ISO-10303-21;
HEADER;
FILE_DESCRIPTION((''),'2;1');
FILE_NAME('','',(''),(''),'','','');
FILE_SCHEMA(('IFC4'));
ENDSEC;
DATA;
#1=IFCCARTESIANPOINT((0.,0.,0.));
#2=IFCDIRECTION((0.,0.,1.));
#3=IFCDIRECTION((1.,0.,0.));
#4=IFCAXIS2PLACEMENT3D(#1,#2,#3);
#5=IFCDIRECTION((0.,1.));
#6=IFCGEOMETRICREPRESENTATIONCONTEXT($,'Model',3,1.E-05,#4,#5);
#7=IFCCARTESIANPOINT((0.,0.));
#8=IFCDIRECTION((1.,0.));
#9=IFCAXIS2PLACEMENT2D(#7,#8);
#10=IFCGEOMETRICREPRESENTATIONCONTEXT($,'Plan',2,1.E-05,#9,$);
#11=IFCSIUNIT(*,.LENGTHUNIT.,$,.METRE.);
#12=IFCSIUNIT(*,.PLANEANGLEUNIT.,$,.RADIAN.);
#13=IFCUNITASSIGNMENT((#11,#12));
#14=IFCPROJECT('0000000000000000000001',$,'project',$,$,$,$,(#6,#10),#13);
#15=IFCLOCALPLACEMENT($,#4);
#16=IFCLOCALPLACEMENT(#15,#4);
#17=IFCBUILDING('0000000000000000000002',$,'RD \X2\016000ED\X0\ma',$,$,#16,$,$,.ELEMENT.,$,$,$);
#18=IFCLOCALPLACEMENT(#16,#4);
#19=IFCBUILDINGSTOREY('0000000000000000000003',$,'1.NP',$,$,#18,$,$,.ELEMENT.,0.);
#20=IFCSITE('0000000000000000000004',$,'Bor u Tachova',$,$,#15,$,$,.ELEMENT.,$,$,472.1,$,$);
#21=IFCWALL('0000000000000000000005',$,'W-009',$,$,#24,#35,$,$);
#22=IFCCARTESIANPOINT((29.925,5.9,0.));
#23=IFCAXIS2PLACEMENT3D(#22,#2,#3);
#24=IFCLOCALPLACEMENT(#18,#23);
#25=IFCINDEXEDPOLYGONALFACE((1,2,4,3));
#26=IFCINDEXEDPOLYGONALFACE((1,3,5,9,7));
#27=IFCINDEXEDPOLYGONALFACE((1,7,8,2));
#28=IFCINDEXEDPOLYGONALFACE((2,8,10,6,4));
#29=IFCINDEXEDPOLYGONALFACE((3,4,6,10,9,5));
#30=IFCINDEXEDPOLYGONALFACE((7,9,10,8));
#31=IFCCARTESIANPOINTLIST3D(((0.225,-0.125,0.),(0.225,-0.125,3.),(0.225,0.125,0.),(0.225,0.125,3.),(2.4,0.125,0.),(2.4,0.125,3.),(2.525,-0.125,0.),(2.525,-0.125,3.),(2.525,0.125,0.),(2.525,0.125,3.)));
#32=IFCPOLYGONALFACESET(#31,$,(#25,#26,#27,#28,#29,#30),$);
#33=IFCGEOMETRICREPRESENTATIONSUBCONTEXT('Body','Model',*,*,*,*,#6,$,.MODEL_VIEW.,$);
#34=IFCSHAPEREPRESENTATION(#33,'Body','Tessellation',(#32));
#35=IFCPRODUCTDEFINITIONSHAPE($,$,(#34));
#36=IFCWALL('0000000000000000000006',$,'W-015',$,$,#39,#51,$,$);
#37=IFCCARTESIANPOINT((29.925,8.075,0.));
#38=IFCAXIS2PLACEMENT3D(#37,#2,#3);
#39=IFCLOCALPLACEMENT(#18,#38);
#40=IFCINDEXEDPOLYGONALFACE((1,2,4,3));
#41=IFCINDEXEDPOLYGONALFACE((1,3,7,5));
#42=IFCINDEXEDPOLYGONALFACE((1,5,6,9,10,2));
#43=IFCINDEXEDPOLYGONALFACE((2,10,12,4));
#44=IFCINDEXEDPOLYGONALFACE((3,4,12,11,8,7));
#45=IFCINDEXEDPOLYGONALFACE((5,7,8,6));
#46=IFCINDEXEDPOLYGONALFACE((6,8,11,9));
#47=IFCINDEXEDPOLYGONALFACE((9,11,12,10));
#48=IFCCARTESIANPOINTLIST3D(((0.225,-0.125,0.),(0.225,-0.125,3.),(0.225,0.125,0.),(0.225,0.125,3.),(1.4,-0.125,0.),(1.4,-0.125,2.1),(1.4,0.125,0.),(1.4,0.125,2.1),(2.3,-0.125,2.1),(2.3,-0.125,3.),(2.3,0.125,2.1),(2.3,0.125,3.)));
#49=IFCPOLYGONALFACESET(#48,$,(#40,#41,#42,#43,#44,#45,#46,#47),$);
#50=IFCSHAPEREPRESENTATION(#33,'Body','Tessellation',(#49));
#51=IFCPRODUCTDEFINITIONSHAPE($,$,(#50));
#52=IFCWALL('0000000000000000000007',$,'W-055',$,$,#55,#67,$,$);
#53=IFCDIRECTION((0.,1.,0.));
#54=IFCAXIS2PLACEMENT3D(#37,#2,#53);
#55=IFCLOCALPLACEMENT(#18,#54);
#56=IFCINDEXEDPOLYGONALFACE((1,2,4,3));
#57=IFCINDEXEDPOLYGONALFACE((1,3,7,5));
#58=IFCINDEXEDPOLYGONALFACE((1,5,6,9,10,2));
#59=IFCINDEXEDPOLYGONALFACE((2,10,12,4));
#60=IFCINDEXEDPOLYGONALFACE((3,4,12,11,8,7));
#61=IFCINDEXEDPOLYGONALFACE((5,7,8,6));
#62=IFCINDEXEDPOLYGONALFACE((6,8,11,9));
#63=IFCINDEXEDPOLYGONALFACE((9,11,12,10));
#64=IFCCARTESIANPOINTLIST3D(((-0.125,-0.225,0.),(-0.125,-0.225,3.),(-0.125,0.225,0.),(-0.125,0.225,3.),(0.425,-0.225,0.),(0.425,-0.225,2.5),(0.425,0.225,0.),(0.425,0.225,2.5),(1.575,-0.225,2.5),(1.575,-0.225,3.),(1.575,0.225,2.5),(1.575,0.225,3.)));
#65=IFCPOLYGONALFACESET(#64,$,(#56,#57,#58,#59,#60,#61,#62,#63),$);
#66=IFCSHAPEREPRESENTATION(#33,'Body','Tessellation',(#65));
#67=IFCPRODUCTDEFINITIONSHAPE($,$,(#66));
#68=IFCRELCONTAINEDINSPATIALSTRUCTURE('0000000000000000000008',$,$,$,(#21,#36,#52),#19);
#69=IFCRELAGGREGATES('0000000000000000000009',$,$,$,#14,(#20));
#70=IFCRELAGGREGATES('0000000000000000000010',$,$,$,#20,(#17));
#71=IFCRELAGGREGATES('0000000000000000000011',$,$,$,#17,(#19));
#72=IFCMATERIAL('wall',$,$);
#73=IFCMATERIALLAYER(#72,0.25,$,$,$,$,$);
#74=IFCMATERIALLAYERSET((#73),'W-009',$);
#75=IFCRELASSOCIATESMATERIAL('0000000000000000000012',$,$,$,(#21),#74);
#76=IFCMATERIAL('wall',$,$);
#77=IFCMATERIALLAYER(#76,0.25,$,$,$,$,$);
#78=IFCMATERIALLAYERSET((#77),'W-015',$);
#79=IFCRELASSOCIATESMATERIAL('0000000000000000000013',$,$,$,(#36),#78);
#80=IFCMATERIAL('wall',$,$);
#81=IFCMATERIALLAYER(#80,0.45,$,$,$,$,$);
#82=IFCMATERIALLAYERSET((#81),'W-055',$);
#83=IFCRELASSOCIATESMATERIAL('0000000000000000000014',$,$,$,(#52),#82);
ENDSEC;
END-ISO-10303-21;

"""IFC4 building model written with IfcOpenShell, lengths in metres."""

from ifc_helpers import new_model, si_unit, direction, frame, frame_2d, origin_with_axes, origin_2d_with_axis, place, context, subcontext, project, spatial, line, indexed_curve, rectangle, outline, extrude, material, layer, layer_set, layer_usage, element, save


model = new_model("IFC4")

# Units and contexts
model_context = context("Model", 3, precision=1e-05, world=origin_with_axes(), true_north=direction((0.0, 1.0)))
plan_context = context("Plan", 2, precision=1e-05, world=origin_2d_with_axis())
body_context = subcontext(model_context, "Body", "Model", "MODEL_VIEW")
ifc_project = project(units=[si_unit("LENGTHUNIT", "METRE"), si_unit("PLANEANGLEUNIT", "RADIAN")], contexts=[model_context, plan_context])

# Site, building, storey
site_placement = place(None, origin_with_axes())
site = spatial("IfcSite", under=ifc_project, at=site_placement, Name="Bor u Tachova", CompositionType="ELEMENT", RefElevation=472.1)
building_placement = place(site_placement, origin_with_axes())
building = spatial("IfcBuilding", under=site, at=building_placement, Name="RD Šíma", CompositionType="ELEMENT")
storey_placement = place(building_placement, origin_with_axes())
storey = spatial("IfcBuildingStorey", under=building, at=storey_placement, Name="1.NP", CompositionType="ELEMENT", Elevation=0.0)

# Wall
ifc_material_1 = material(Name="wall")
ifc_layer_1 = layer(ifc_material_1, 0.25)
ifc_layer_set_1 = layer_set([ifc_layer_1], Name="W-009")
ifc_layer_usage_1 = layer_usage(ifc_layer_set_1, "AXIS2", "POSITIVE", -0.125)
wall_1_placement = place(storey_placement, frame((29.925, 5.9, 0.0), z_axis=(0.0, 0.0, 1.0), x_axis=(1.0, 0.0, 0.0)))
element("IfcWall", 1, at=wall_1_placement, inside=storey, material=ifc_layer_usage_1, Name="W-009", context=body_context, shape_type="SweptSolid", body=[
    extrude(outline(indexed_curve([(0.225, -0.125), (0.225, 0.125), (2.4, 0.125), (2.525, 0.125), (2.525, -0.125)], segments=[line(1, 2, 3, 4, 5, 1)])), origin_with_axes(), (0.0, 0.0, 1.0), 3.0),
])

# Wall, opening
ifc_material_2 = material(Name="wall")
ifc_layer_2 = layer(ifc_material_2, 0.25)
ifc_layer_set_2 = layer_set([ifc_layer_2], Name="W-015")
ifc_layer_usage_2 = layer_usage(ifc_layer_set_2, "AXIS2", "POSITIVE", -0.125)
wall_2_placement = place(storey_placement, frame((29.925, 8.075, 0.0), z_axis=(0.0, 0.0, 1.0), x_axis=(1.0, 0.0, 0.0)))
wall_2 = element("IfcWall", 2, at=wall_2_placement, inside=storey, material=ifc_layer_usage_2, Name="W-015", context=body_context, shape_type="SweptSolid", body=[
    extrude(outline(indexed_curve([(0.225, -0.125), (0.225, 0.125), (2.3, 0.125), (2.3, -0.125)], segments=[line(1, 2, 3, 4, 1)])), origin_with_axes(), (0.0, 0.0, 1.0), 3.0),
])
opening_1_placement = place(wall_2_placement, frame((1.4, 0.0, 0.0), z_axis=(0.0, 0.0, 1.0), x_axis=(1.0, 0.0, 0.0)))
element("IfcOpeningElement", 3, at=opening_1_placement, cuts=wall_2, PredefinedType="OPENING", context=body_context, shape_type="SweptSolid", body=[
    extrude(rectangle(XDim=0.9, YDim=0.25, at=frame_2d((0.45, 0.0))), origin_with_axes(), (0.0, 0.0, 1.0), 2.1),
])

# Wall, opening
ifc_material_3 = material(Name="wall")
ifc_layer_3 = layer(ifc_material_3, 0.45)
ifc_layer_set_3 = layer_set([ifc_layer_3], Name="W-055")
ifc_layer_usage_3 = layer_usage(ifc_layer_set_3, "AXIS2", "POSITIVE", -0.225)
wall_3_placement = place(storey_placement, frame((29.925, 8.075, 0.0), z_axis=(0.0, 0.0, 1.0), x_axis=(0.0, 1.0, 0.0)))
wall_3 = element("IfcWall", 4, at=wall_3_placement, inside=storey, material=ifc_layer_usage_3, Name="W-055", context=body_context, shape_type="SweptSolid", body=[
    extrude(outline(indexed_curve([(0.125, -0.225), (-0.125, -0.225), (-0.125, 0.225), (1.575, 0.225), (1.575, -0.225)], segments=[line(1, 2, 3, 4, 5, 1)])), origin_with_axes(), (0.0, 0.0, 1.0), 3.0),
])
opening_2_placement = place(wall_3_placement, frame((0.425, 0.0, 0.0), z_axis=(0.0, 0.0, 1.0), x_axis=(1.0, 0.0, 0.0)))
element("IfcOpeningElement", 5, at=opening_2_placement, cuts=wall_3, PredefinedType="OPENING", context=body_context, shape_type="SweptSolid", body=[
    extrude(rectangle(XDim=1.15, YDim=0.45, at=frame_2d((0.575, 0.0))), origin_with_axes(), (0.0, 0.0, 1.0), 2.5),
])

save(model, "model.ifc")
